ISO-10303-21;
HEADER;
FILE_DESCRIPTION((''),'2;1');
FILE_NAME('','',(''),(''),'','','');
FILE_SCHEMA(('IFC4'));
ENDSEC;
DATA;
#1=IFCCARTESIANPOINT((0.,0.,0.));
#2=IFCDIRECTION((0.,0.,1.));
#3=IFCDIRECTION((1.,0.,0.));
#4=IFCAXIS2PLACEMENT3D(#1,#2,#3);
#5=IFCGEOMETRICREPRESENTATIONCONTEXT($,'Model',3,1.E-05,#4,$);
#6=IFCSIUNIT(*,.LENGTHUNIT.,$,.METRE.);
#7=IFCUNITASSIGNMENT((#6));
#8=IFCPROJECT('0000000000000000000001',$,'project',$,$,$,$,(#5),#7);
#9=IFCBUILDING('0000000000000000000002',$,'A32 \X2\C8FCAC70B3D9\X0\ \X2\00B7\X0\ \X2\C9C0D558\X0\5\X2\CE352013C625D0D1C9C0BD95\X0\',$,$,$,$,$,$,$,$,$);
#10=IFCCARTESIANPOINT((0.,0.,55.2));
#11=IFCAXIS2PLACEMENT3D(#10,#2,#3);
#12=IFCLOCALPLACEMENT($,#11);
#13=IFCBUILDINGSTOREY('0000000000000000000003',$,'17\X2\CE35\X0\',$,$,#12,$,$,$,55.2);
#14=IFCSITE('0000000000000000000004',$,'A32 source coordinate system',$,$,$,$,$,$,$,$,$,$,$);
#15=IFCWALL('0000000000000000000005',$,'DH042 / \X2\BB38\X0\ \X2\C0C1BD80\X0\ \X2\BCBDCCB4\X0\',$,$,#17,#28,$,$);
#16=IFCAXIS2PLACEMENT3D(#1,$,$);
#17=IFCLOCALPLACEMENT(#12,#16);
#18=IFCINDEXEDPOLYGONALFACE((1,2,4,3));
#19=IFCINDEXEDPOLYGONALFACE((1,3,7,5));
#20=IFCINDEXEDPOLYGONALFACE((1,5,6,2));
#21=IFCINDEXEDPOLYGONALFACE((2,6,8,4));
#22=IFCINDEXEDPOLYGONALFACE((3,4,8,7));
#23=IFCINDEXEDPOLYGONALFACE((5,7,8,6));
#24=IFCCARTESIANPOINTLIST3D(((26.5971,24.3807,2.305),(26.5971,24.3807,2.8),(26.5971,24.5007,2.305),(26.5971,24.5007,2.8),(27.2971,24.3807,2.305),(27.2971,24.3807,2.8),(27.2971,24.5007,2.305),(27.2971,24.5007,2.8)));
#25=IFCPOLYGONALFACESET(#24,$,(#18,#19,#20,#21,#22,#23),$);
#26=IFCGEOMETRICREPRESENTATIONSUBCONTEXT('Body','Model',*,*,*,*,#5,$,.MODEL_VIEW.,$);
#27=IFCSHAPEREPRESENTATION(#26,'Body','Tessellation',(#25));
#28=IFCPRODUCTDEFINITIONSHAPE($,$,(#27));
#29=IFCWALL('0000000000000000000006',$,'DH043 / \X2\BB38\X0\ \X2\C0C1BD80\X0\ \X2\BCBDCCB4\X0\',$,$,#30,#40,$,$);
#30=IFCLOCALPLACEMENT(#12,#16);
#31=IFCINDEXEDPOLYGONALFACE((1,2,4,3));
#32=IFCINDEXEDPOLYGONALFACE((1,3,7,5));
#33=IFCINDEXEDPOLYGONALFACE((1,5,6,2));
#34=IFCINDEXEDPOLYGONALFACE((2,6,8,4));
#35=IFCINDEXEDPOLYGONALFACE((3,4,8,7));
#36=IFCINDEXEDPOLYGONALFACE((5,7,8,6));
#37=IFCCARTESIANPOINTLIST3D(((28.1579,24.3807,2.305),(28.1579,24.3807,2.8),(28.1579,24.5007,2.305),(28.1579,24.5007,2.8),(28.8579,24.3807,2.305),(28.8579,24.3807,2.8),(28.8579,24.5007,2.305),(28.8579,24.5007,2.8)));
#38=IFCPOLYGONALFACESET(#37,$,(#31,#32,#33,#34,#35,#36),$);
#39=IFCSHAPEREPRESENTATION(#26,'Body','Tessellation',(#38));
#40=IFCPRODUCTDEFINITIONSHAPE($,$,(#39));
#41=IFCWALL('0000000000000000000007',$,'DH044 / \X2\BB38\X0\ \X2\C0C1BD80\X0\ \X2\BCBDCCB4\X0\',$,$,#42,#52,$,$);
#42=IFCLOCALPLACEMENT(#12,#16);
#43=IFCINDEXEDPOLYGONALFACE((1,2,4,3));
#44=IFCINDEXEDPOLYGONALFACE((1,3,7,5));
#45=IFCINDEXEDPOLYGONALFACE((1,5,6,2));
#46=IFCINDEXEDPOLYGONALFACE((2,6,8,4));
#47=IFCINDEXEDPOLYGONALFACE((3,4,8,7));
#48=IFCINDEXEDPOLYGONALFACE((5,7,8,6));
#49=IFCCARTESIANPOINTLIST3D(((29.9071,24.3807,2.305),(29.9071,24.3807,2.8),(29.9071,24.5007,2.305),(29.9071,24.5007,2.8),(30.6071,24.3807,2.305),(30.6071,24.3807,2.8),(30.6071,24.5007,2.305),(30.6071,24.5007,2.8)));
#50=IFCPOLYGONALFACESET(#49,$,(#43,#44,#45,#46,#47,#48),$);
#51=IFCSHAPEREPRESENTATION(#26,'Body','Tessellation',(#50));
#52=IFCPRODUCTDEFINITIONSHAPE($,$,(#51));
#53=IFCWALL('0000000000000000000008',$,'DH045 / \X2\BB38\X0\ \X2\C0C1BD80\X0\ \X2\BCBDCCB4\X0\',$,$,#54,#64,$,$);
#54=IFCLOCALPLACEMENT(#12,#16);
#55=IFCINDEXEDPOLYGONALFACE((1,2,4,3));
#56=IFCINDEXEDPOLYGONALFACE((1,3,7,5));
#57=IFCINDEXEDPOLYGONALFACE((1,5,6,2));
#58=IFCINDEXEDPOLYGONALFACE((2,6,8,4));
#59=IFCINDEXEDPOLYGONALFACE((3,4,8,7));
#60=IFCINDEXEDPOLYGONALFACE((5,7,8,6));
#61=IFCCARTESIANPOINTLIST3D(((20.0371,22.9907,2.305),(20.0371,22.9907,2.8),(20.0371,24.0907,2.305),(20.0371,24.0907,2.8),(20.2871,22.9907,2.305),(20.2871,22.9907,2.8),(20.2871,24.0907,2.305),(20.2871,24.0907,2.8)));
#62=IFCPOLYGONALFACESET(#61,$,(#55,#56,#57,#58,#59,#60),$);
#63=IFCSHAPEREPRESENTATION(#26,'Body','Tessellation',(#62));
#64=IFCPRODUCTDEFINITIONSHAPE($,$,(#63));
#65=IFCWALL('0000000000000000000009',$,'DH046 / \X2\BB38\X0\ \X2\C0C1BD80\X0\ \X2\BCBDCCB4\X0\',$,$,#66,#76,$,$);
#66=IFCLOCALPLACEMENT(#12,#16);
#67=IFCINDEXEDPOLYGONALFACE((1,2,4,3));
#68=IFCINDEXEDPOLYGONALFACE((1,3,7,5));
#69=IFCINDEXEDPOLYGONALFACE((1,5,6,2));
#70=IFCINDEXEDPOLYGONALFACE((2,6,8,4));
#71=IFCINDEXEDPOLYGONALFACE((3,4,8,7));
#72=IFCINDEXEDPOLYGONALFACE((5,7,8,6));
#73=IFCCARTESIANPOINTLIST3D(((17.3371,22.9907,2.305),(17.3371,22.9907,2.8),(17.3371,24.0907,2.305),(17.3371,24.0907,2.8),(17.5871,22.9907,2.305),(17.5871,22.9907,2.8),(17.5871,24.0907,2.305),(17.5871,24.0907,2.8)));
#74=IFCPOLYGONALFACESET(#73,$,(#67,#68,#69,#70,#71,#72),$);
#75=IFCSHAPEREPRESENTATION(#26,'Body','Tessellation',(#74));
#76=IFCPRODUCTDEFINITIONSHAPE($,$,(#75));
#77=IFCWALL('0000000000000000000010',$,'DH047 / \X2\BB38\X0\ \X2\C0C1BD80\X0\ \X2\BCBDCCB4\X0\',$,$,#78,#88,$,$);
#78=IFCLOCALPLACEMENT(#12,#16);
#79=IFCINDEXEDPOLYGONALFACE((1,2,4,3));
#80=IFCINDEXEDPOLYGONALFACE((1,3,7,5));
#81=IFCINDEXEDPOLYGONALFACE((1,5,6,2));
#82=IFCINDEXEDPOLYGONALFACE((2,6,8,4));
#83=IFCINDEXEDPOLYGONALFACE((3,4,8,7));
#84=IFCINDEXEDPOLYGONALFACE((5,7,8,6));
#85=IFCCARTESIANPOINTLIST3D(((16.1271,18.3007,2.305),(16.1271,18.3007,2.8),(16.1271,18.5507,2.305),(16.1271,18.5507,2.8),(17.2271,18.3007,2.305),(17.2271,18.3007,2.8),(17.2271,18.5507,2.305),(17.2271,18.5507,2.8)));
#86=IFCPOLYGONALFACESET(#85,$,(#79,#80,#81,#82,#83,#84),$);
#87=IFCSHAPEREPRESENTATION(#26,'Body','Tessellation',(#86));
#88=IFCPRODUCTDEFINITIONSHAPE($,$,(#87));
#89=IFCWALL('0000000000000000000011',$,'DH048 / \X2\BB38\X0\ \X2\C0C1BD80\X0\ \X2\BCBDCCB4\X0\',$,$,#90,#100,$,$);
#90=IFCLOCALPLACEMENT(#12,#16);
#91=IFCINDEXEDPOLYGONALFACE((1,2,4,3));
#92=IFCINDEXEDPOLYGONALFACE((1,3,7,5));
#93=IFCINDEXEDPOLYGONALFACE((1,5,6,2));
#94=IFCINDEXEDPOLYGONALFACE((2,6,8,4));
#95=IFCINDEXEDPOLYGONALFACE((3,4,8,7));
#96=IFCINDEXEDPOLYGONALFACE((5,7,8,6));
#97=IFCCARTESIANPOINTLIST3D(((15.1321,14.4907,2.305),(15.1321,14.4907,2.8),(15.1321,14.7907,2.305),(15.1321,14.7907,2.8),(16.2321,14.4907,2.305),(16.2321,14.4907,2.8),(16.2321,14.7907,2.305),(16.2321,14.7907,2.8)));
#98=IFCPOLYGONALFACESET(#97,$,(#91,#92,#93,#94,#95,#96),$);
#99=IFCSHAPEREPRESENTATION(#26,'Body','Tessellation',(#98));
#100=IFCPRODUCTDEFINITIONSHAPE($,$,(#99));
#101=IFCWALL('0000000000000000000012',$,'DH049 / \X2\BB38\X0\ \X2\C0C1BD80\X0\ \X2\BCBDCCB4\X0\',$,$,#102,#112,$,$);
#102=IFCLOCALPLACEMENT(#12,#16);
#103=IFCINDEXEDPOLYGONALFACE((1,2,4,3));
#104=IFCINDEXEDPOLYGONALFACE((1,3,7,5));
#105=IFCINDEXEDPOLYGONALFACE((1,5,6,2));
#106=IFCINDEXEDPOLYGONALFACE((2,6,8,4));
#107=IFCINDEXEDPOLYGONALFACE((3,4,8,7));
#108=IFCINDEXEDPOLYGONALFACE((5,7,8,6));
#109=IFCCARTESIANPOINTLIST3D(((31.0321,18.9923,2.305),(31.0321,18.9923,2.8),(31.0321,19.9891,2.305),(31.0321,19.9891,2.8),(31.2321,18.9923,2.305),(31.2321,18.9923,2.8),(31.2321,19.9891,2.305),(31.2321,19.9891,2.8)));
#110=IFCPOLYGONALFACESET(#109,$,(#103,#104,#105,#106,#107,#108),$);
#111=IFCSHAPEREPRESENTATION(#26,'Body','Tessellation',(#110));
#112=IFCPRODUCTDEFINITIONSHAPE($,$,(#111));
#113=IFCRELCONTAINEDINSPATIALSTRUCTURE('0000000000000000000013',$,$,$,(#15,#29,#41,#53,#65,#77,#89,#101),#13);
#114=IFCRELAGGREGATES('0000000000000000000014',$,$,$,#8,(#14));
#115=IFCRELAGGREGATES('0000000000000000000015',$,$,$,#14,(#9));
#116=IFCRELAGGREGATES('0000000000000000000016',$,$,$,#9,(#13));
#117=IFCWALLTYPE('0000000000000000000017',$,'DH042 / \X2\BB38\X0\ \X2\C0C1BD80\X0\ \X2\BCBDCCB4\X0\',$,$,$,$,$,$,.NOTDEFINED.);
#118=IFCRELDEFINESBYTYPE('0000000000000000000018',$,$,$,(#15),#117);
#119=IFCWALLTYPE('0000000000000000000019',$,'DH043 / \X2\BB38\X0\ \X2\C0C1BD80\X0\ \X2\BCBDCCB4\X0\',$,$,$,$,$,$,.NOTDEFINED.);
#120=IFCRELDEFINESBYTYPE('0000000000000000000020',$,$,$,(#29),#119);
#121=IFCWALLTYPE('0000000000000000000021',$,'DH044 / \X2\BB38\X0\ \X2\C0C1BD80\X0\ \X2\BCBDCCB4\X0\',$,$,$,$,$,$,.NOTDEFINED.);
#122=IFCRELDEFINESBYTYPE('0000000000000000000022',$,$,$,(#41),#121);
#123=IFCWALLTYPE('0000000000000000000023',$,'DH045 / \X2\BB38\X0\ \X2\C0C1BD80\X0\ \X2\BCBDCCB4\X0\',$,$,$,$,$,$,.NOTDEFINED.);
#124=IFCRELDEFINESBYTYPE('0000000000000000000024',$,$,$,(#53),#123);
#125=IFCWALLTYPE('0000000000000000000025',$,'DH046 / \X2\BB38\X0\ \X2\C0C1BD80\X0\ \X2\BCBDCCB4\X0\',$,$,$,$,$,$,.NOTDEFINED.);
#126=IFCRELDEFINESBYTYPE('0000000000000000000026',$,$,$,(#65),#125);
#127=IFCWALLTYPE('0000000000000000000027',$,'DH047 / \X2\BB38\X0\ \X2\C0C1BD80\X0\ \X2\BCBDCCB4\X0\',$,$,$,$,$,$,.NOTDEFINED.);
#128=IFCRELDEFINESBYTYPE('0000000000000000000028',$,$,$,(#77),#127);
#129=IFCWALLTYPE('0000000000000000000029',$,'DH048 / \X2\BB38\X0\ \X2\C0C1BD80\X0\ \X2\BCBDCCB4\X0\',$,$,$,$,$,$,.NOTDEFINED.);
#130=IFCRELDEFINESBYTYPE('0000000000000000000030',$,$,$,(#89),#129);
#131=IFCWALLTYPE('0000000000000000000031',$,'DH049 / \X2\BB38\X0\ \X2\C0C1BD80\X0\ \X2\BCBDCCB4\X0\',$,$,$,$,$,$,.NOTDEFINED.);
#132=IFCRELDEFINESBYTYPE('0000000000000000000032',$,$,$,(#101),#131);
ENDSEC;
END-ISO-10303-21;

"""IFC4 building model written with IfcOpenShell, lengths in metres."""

from ifc_helpers import new_model, si_unit, frame, origin, origin_with_axes, place, context, subcontext, project, spatial, polyline, outline, extrude, source, transform, mapped, type_object, type_shapes, element, save


model = new_model("IFC4")

# Units and contexts
model_context = context("Model", 3, precision=1e-05, world=origin_with_axes())
body_context = subcontext(model_context, "Body", "Model", "MODEL_VIEW")
ifc_project = project(units=[si_unit("LENGTHUNIT", "METRE")], contexts=[model_context])

# Site, building, storey
site = spatial("IfcSite", under=ifc_project, Name="A32 source coordinate system")
building = spatial("IfcBuilding", under=site, Name="A32 주거동 · 지하5층–옥탑지붕")
storey_placement = place(None, frame((0.0, 0.0, 55.2), z_axis=(0.0, 0.0, 1.0), x_axis=(1.0, 0.0, 0.0)))
storey = spatial("IfcBuildingStorey", under=building, at=storey_placement, Name="17층", Elevation=55.2)

# Walls
wall_type_1 = type_object("IfcWallType", Name="DH042 / 문 상부 벽체", PredefinedType="NOTDEFINED")
shared_shape_1 = source(origin(), body_context, "Body", "SweptSolid", [
    extrude(outline(polyline([(27.2971, 24.3807), (26.5971, 24.3807), (26.5971, 24.5007), (27.2971, 24.5007), (27.2971, 24.3807)])), frame((0.0, 0.0, 2.305)), (0.0, 0.0, 1.0), 0.495),
])
type_shapes(wall_type_1, [shared_shape_1])
wall_1_placement = place(storey_placement, origin_with_axes())
element("IfcWall", 1, at=wall_1_placement, inside=storey, type_object=wall_type_1, Name="DH042 / 문 상부 벽체", context=body_context, shape_type="MappedRepresentation", body=[
    mapped(shared_shape_1, transform((0.0, 0.0, 0.0), scale=1.0)),
])
wall_type_2 = type_object("IfcWallType", Name="DH043 / 문 상부 벽체", PredefinedType="NOTDEFINED")
shared_shape_2 = source(origin(), body_context, "Body", "SweptSolid", [
    extrude(outline(polyline([(28.8579, 24.3807), (28.1579, 24.3807), (28.1579, 24.5007), (28.8579, 24.5007), (28.8579, 24.3807)])), frame((0.0, 0.0, 2.305)), (0.0, 0.0, 1.0), 0.495),
])
type_shapes(wall_type_2, [shared_shape_2])
wall_2_placement = place(storey_placement, origin_with_axes())
element("IfcWall", 2, at=wall_2_placement, inside=storey, type_object=wall_type_2, Name="DH043 / 문 상부 벽체", context=body_context, shape_type="MappedRepresentation", body=[
    mapped(shared_shape_2, transform((0.0, 0.0, 0.0), scale=1.0)),
])
wall_type_3 = type_object("IfcWallType", Name="DH044 / 문 상부 벽체", PredefinedType="NOTDEFINED")
shared_shape_3 = source(origin(), body_context, "Body", "SweptSolid", [
    extrude(outline(polyline([(30.6071, 24.3807), (29.9071, 24.3807), (29.9071, 24.5007), (30.6071, 24.5007), (30.6071, 24.3807)])), frame((0.0, 0.0, 2.305)), (0.0, 0.0, 1.0), 0.495),
])
type_shapes(wall_type_3, [shared_shape_3])
wall_3_placement = place(storey_placement, origin_with_axes())
element("IfcWall", 3, at=wall_3_placement, inside=storey, type_object=wall_type_3, Name="DH044 / 문 상부 벽체", context=body_context, shape_type="MappedRepresentation", body=[
    mapped(shared_shape_3, transform((0.0, 0.0, 0.0), scale=1.0)),
])
wall_type_4 = type_object("IfcWallType", Name="DH045 / 문 상부 벽체", PredefinedType="NOTDEFINED")
shared_shape_4 = source(origin(), body_context, "Body", "SweptSolid", [
    extrude(outline(polyline([(20.2871, 22.9907), (20.0371, 22.9907), (20.0371, 24.0907), (20.2871, 24.0907), (20.2871, 22.9907)])), frame((0.0, 0.0, 2.305)), (0.0, 0.0, 1.0), 0.495),
])
type_shapes(wall_type_4, [shared_shape_4])
wall_4_placement = place(storey_placement, origin_with_axes())
element("IfcWall", 4, at=wall_4_placement, inside=storey, type_object=wall_type_4, Name="DH045 / 문 상부 벽체", context=body_context, shape_type="MappedRepresentation", body=[
    mapped(shared_shape_4, transform((0.0, 0.0, 0.0), scale=1.0)),
])
wall_type_5 = type_object("IfcWallType", Name="DH046 / 문 상부 벽체", PredefinedType="NOTDEFINED")
shared_shape_5 = source(origin(), body_context, "Body", "SweptSolid", [
    extrude(outline(polyline([(17.5871, 22.9907), (17.3371, 22.9907), (17.3371, 24.0907), (17.5871, 24.0907), (17.5871, 22.9907)])), frame((0.0, 0.0, 2.305)), (0.0, 0.0, 1.0), 0.495),
])
type_shapes(wall_type_5, [shared_shape_5])
wall_5_placement = place(storey_placement, origin_with_axes())
element("IfcWall", 5, at=wall_5_placement, inside=storey, type_object=wall_type_5, Name="DH046 / 문 상부 벽체", context=body_context, shape_type="MappedRepresentation", body=[
    mapped(shared_shape_5, transform((0.0, 0.0, 0.0), scale=1.0)),
])
wall_type_6 = type_object("IfcWallType", Name="DH047 / 문 상부 벽체", PredefinedType="NOTDEFINED")
shared_shape_6 = source(origin(), body_context, "Body", "SweptSolid", [
    extrude(outline(polyline([(17.2271, 18.3007), (16.1271, 18.3007), (16.1271, 18.5507), (17.2271, 18.5507), (17.2271, 18.3007)])), frame((0.0, 0.0, 2.305)), (0.0, 0.0, 1.0), 0.495),
])
type_shapes(wall_type_6, [shared_shape_6])
wall_6_placement = place(storey_placement, origin_with_axes())
element("IfcWall", 6, at=wall_6_placement, inside=storey, type_object=wall_type_6, Name="DH047 / 문 상부 벽체", context=body_context, shape_type="MappedRepresentation", body=[
    mapped(shared_shape_6, transform((0.0, 0.0, 0.0), scale=1.0)),
])
wall_type_7 = type_object("IfcWallType", Name="DH048 / 문 상부 벽체", PredefinedType="NOTDEFINED")
shared_shape_7 = source(origin(), body_context, "Body", "SweptSolid", [
    extrude(outline(polyline([(15.1321, 14.7907), (16.2321, 14.7907), (16.2321, 14.4907), (15.1321, 14.4907), (15.1321, 14.7907)])), frame((0.0, 0.0, 2.305)), (0.0, 0.0, 1.0), 0.495),
])
type_shapes(wall_type_7, [shared_shape_7])
wall_7_placement = place(storey_placement, origin_with_axes())
element("IfcWall", 7, at=wall_7_placement, inside=storey, type_object=wall_type_7, Name="DH048 / 문 상부 벽체", context=body_context, shape_type="MappedRepresentation", body=[
    mapped(shared_shape_7, transform((0.0, 0.0, 0.0), scale=1.0)),
])
wall_type_8 = type_object("IfcWallType", Name="DH049 / 문 상부 벽체", PredefinedType="NOTDEFINED")
shared_shape_8 = source(origin(), body_context, "Body", "SweptSolid", [
    extrude(outline(polyline([(31.2321, 18.9923), (31.0321, 18.9923), (31.0321, 19.9891), (31.2321, 19.9891), (31.2321, 18.9923)])), frame((0.0, 0.0, 2.305)), (0.0, 0.0, 1.0), 0.495),
])
type_shapes(wall_type_8, [shared_shape_8])
wall_8_placement = place(storey_placement, origin_with_axes())
element("IfcWall", 8, at=wall_8_placement, inside=storey, type_object=wall_type_8, Name="DH049 / 문 상부 벽체", context=body_context, shape_type="MappedRepresentation", body=[
    mapped(shared_shape_8, transform((0.0, 0.0, 0.0), scale=1.0)),
])

save(model, "model.ifc")
